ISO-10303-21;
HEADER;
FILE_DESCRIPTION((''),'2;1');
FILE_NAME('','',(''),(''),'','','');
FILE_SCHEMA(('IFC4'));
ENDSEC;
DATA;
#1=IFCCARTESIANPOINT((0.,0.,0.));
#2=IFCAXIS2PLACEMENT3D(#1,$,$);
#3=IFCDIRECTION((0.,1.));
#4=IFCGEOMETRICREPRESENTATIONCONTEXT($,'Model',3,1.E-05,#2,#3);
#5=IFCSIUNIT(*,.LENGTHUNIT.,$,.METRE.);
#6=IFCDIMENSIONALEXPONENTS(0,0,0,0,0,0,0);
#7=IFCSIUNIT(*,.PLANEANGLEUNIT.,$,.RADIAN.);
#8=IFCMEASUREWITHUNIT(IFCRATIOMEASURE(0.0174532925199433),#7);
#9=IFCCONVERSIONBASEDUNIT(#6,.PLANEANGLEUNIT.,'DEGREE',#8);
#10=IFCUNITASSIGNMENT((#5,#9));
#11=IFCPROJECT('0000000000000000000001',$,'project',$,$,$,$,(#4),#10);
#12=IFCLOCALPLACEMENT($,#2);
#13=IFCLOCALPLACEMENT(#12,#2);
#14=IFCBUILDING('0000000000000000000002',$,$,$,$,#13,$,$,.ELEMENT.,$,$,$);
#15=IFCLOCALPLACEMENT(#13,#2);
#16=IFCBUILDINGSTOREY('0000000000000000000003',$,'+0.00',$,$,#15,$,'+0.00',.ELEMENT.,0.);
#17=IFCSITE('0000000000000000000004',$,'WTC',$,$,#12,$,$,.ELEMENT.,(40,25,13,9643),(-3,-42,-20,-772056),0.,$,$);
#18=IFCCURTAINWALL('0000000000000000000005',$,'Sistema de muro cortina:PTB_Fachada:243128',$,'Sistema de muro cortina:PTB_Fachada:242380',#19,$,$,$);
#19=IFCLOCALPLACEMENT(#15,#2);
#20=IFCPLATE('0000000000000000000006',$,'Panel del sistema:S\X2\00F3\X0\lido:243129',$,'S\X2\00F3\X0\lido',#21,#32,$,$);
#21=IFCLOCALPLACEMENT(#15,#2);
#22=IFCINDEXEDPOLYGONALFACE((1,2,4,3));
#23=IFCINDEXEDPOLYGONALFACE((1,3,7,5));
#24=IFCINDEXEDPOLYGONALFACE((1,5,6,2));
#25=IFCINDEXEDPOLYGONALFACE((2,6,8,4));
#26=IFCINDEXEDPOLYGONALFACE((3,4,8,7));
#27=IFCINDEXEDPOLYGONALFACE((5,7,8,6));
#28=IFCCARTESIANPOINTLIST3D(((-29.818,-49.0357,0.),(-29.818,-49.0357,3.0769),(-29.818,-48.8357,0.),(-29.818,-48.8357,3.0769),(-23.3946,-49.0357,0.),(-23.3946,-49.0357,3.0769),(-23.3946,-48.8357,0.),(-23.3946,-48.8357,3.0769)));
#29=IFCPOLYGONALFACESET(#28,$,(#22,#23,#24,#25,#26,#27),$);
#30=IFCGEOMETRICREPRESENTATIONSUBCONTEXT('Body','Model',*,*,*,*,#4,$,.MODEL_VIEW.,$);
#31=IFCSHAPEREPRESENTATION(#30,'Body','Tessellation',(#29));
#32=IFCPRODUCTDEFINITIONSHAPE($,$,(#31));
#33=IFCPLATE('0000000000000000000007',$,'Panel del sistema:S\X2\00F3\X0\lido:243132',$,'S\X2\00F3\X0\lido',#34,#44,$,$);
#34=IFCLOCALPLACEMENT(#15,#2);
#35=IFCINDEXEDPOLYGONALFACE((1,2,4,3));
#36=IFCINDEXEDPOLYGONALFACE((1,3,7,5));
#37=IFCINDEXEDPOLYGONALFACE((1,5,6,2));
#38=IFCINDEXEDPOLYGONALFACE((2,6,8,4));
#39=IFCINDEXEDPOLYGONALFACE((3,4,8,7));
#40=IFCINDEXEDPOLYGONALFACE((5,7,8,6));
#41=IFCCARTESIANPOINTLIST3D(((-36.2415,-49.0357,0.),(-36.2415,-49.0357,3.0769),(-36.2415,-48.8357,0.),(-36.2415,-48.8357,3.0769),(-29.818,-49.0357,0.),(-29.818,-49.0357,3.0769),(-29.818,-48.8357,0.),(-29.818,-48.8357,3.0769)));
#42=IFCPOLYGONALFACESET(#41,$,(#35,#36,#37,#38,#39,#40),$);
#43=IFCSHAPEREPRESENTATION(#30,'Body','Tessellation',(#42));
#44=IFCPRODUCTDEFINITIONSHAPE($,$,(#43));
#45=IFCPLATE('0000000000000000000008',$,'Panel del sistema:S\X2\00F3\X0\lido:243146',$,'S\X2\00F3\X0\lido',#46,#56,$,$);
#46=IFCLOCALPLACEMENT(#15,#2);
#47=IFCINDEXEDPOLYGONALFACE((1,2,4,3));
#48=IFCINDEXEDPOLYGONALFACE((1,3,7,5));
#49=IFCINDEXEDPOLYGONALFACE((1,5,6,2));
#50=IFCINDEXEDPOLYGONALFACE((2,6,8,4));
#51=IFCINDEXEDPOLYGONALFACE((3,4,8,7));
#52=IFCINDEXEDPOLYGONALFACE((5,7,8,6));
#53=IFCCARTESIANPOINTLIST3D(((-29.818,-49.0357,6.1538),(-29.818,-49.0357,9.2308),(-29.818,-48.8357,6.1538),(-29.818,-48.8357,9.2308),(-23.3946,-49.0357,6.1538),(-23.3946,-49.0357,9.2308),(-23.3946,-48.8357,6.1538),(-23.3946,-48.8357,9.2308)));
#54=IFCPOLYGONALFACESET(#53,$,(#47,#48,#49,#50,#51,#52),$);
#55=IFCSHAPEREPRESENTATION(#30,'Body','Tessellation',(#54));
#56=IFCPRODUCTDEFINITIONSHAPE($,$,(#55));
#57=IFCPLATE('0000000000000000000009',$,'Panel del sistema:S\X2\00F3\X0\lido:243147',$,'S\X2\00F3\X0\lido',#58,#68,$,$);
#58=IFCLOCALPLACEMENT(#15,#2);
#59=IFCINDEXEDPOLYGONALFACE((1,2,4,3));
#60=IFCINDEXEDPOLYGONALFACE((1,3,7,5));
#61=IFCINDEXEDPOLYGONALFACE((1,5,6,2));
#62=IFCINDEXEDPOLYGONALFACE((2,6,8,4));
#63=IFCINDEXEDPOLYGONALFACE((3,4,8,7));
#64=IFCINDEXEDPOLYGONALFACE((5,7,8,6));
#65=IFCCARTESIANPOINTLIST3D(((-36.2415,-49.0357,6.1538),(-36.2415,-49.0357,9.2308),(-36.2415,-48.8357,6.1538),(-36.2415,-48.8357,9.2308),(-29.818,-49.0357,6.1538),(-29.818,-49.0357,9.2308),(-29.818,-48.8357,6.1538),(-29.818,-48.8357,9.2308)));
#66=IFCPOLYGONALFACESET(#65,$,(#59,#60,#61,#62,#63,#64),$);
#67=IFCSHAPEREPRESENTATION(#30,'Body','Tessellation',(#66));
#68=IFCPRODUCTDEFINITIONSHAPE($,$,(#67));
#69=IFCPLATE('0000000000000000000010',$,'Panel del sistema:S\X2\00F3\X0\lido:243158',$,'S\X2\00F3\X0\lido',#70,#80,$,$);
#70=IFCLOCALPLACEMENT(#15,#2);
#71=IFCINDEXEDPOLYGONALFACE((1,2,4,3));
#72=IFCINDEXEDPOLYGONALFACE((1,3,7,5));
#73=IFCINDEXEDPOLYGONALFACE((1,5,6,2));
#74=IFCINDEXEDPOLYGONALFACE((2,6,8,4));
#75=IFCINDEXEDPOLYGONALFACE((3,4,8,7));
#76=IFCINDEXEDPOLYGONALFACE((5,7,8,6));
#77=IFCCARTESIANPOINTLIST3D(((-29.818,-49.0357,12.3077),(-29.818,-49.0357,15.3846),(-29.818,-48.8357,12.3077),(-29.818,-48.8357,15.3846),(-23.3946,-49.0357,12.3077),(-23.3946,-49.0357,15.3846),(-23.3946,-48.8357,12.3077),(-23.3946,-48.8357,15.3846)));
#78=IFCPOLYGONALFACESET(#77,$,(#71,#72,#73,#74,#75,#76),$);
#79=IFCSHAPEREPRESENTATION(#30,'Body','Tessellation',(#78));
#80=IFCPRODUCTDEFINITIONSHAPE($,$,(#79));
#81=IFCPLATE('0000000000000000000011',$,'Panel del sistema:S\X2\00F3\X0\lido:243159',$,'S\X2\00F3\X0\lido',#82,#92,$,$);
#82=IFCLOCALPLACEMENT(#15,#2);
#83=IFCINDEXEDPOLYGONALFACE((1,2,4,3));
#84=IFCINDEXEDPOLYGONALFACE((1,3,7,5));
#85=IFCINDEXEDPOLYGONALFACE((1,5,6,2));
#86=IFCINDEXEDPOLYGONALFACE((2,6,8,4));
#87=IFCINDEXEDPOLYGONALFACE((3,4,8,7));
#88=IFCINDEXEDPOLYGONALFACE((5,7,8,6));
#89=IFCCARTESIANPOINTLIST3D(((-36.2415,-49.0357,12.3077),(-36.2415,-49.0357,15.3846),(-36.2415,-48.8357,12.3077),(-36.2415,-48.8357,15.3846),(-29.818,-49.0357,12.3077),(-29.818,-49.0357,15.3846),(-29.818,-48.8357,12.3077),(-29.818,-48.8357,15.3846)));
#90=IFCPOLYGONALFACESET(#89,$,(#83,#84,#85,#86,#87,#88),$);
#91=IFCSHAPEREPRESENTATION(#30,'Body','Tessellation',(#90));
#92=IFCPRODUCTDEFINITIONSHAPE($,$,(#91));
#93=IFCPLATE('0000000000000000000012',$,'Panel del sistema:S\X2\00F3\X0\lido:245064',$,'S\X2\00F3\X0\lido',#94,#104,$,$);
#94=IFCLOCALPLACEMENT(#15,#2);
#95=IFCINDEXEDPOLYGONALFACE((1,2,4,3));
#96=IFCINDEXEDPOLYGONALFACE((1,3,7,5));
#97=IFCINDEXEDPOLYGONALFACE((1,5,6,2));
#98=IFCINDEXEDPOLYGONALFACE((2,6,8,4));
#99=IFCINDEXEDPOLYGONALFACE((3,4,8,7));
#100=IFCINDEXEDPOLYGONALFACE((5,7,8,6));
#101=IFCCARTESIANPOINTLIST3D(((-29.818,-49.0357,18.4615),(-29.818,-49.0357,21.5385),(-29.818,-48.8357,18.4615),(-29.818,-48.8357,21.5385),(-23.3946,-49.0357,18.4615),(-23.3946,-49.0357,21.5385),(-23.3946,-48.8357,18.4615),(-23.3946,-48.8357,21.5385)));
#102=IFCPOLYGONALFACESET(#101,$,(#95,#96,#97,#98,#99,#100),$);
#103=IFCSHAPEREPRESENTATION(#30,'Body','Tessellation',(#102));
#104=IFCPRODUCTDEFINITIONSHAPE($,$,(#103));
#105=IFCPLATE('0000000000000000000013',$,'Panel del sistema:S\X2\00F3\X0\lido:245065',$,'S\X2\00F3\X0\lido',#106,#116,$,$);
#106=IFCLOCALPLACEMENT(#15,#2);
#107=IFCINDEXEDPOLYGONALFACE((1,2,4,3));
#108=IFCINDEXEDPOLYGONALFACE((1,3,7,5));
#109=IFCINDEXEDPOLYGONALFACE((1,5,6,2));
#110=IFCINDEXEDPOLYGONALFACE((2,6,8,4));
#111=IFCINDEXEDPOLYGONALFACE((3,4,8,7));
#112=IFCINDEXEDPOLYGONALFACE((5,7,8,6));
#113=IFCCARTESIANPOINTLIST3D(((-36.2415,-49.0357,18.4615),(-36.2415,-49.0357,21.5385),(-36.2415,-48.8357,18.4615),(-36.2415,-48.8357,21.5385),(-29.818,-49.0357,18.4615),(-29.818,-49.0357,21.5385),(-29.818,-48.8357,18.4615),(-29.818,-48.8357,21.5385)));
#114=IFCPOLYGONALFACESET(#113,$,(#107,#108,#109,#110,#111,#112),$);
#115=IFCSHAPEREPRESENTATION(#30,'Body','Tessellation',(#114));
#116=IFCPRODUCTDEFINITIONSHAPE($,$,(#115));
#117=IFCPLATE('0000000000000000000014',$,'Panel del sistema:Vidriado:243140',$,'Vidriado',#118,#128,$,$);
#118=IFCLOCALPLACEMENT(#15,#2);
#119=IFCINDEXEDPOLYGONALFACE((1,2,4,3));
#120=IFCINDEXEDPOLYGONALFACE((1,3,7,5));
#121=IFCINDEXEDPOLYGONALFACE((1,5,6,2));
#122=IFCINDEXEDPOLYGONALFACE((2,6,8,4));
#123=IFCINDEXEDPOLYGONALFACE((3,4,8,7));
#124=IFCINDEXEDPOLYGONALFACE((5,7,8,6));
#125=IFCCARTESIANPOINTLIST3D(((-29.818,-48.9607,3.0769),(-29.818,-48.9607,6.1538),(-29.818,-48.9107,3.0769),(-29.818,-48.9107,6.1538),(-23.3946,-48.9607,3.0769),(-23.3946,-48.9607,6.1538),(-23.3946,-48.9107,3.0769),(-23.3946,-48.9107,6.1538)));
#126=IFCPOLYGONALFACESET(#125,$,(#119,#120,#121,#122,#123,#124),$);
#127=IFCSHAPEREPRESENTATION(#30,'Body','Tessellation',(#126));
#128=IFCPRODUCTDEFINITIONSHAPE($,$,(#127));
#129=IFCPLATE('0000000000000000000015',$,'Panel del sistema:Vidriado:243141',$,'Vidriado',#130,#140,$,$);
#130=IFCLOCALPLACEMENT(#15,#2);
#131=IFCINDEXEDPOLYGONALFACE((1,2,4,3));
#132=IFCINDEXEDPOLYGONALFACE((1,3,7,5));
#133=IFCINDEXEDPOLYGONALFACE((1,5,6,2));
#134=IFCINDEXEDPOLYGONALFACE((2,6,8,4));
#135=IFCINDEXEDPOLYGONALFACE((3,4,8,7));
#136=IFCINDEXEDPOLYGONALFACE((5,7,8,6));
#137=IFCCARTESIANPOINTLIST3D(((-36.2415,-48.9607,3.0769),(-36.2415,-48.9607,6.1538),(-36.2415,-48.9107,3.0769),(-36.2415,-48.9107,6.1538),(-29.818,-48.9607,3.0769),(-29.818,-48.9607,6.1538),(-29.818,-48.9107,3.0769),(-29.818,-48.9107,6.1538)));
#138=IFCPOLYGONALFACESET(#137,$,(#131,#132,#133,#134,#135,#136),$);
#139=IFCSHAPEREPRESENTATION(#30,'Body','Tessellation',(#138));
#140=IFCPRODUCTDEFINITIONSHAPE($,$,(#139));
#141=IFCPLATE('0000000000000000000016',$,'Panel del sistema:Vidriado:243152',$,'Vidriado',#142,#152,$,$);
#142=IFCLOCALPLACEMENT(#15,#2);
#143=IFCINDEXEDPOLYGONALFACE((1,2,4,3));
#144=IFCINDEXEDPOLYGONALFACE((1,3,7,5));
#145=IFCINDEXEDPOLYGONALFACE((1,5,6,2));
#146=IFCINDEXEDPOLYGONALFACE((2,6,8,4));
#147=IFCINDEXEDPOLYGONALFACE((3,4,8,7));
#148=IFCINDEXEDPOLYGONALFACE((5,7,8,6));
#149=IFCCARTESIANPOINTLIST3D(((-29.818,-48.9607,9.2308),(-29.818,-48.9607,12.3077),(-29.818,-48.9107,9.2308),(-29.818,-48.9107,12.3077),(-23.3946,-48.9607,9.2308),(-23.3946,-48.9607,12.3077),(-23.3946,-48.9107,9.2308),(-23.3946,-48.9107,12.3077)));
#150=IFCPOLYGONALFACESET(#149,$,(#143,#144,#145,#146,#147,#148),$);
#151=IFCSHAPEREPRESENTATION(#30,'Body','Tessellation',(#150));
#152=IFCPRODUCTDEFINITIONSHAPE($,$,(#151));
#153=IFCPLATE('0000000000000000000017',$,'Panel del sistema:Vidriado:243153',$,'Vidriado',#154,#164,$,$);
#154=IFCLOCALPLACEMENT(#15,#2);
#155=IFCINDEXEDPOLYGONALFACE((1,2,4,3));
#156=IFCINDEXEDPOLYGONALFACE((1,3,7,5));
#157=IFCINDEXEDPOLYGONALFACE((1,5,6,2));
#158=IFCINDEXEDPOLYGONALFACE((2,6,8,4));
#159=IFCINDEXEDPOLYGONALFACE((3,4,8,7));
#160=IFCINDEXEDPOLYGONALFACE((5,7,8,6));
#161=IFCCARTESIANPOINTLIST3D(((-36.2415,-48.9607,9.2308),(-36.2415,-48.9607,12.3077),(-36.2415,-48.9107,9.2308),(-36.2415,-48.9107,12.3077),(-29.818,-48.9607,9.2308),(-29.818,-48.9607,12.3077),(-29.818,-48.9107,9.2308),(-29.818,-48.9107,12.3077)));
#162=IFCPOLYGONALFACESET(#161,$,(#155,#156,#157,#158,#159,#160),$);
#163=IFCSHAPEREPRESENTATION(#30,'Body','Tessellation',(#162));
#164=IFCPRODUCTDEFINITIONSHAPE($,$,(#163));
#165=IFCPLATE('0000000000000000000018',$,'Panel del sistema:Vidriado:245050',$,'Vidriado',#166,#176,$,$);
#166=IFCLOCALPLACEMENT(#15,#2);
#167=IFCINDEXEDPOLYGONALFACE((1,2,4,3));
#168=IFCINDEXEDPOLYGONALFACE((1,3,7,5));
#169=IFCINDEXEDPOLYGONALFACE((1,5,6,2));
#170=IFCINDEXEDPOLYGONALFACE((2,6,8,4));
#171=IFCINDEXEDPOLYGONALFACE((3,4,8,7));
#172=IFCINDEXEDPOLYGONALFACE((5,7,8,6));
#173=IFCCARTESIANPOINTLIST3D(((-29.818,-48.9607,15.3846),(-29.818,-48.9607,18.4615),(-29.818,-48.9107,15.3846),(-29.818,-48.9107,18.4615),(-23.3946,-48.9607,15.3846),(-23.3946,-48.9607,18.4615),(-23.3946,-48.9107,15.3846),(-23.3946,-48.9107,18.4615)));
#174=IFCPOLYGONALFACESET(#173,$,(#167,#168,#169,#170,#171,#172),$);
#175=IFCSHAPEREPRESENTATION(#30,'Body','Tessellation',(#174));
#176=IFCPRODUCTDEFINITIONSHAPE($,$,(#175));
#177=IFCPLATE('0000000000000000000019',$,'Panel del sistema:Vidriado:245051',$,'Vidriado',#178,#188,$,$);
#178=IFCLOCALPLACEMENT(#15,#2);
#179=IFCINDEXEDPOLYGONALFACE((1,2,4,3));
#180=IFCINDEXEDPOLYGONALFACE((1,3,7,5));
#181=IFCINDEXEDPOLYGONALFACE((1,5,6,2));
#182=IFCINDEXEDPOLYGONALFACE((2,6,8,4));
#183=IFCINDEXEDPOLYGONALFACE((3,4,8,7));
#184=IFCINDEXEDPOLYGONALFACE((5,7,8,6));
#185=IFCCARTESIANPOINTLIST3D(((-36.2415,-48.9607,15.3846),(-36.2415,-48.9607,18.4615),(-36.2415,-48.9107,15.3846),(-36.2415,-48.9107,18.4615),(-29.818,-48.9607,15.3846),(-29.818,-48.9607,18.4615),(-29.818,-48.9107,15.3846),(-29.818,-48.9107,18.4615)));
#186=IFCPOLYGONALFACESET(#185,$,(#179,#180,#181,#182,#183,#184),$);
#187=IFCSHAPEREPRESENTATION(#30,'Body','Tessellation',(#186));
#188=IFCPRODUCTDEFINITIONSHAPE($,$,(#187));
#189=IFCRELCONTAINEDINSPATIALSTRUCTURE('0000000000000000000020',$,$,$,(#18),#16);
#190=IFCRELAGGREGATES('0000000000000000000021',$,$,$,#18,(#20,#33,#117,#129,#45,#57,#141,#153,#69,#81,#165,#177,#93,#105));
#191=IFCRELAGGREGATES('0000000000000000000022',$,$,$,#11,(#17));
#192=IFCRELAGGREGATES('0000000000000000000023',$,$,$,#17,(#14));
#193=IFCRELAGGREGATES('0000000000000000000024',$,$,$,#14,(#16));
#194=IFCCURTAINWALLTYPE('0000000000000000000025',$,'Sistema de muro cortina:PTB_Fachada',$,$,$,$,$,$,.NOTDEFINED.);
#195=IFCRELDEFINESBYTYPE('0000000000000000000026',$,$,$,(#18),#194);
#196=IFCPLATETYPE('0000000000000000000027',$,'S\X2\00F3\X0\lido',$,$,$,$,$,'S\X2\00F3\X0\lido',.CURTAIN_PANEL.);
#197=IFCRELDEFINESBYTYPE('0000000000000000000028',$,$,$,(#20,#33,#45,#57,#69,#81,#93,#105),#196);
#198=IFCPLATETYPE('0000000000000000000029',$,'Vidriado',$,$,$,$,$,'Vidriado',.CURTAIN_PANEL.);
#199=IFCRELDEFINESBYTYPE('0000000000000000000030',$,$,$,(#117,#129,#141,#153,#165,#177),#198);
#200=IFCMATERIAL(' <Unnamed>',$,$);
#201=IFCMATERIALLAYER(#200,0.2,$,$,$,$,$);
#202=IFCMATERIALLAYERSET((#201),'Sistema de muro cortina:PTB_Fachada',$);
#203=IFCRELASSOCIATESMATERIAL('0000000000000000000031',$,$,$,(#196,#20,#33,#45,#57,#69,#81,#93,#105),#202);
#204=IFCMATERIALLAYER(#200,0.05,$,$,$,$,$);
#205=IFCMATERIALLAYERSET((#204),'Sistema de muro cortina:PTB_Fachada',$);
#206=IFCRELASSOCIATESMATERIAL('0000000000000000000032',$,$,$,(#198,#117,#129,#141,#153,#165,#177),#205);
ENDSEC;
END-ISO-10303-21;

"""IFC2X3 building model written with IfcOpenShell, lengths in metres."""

from ifc_helpers import new_model, entity, si_unit, converted_unit, direction, frame, origin, origin_2d_with_axis, place, context, subcontext, project, spatial, rectangle, extrude, source, transform, mapped, material, layer, layer_set, layer_usage, type_object, type_shapes, element, aggregate, save


model = new_model("IFC2X3")

# Units and contexts
model_context = context("Model", 3, precision=1e-05, world=origin(), true_north=direction((0.0, 1.0)))
body_context = subcontext(model_context, "Body", "Model", "MODEL_VIEW")
ifc_project = project(units=[si_unit("LENGTHUNIT", "METRE"), converted_unit("PLANEANGLEUNIT", "DEGREE", entity("IfcRatioMeasure", 0.0174532925199433), si_unit("PLANEANGLEUNIT", "RADIAN"), dimensions=[0, 0, 0, 0, 0, 0, 0])], contexts=[model_context])

# Site, building, storey
site_placement = place(None, origin())
site = spatial("IfcSite", under=ifc_project, at=site_placement, Name="WTC", CompositionType="ELEMENT", RefLatitude=(40, 25, 13, 9643), RefLongitude=(-3, -42, -20, -772056), RefElevation=0.0)
building_placement = place(site_placement, origin())
building = spatial("IfcBuilding", under=site, at=building_placement, CompositionType="ELEMENT")
storey_placement = place(building_placement, origin())
storey = spatial("IfcBuildingStorey", under=building, at=storey_placement, Name="+0.00", LongName="+0.00", CompositionType="ELEMENT", Elevation=0.0)

# Curtain wall, plates
curtain_wall_type = type_object("IfcCurtainWallType", Name="Sistema de muro cortina:PTB_Fachada", PredefinedType="NOTDEFINED")
ifc_material = material(Name=" <Unnamed>")
ifc_layer_1 = layer(ifc_material, 0.2)
ifc_layer_set_1 = layer_set([ifc_layer_1], Name="Sistema de muro cortina:PTB_Fachada")
ifc_layer_2 = layer(ifc_material, 0.05)
ifc_layer_set_2 = layer_set([ifc_layer_2], Name="Sistema de muro cortina:PTB_Fachada")
curtain_wall_1_placement = place(storey_placement, origin())
curtain_wall_1 = element("IfcCurtainWall", 1, at=curtain_wall_1_placement, inside=storey, type_object=curtain_wall_type, Name="Sistema de muro cortina:PTB_Fachada:243128", ObjectType="Sistema de muro cortina:PTB_Fachada:242380")
ifc_layer_usage_1 = layer_usage(ifc_layer_set_1, "AXIS3", "POSITIVE", 0.0)
plate_type_1 = type_object("IfcPlateType", Name="Sólido", ElementType="Sólido", PredefinedType="CURTAIN_PANEL", material=ifc_layer_set_1)
shared_shape_1 = source(origin(), body_context, "Body", "SweptSolid", [
    extrude(rectangle(XDim=0.2, YDim=6.4235, at=origin_2d_with_axis()), frame((0.0, 0.0, 0.0), z_axis=(0.0, 0.0, 1.0), x_axis=(0.0, 1.0, 0.0)), (0.0, 0.0, 1.0), 3.0769),
])
type_shapes(plate_type_1, [shared_shape_1])
plate_1_placement = place(curtain_wall_1_placement, frame((-26.6063, -48.9357, 0.0), z_axis=(0.0, 0.0, 1.0), x_axis=(-1.0, 0.0, 0.0)))
plate_1 = element("IfcPlate", 2, at=plate_1_placement, type_object=plate_type_1, material=ifc_layer_usage_1, Name="Panel del sistema:Sólido:243129", ObjectType="Sólido", context=body_context, shape_type="MappedRepresentation", body=[
    mapped(shared_shape_1, transform((0.0, 0.0, 0.0), scale=1.0)),
])
ifc_layer_usage_2 = layer_usage(ifc_layer_set_1, "AXIS3", "POSITIVE", 0.0)
plate_2_placement = place(curtain_wall_1_placement, frame((-33.0298, -48.9357, 0.0), z_axis=(0.0, 0.0, 1.0), x_axis=(-1.0, 0.0, 0.0)))
plate_2 = element("IfcPlate", 3, at=plate_2_placement, type_object=plate_type_1, material=ifc_layer_usage_2, Name="Panel del sistema:Sólido:243132", ObjectType="Sólido", context=body_context, shape_type="MappedRepresentation", body=[
    mapped(shared_shape_1, transform((0.0, 0.0, 0.0), scale=1.0)),
])
ifc_layer_usage_3 = layer_usage(ifc_layer_set_1, "AXIS3", "POSITIVE", 0.0)
plate_3_placement = place(curtain_wall_1_placement, frame((-26.6063, -48.9357, 6.1538), z_axis=(0.0, 0.0, 1.0), x_axis=(-1.0, 0.0, 0.0)))
plate_3 = element("IfcPlate", 4, at=plate_3_placement, type_object=plate_type_1, material=ifc_layer_usage_3, Name="Panel del sistema:Sólido:243146", ObjectType="Sólido", context=body_context, shape_type="MappedRepresentation", body=[
    mapped(shared_shape_1, transform((0.0, 0.0, 0.0), scale=1.0)),
])
ifc_layer_usage_4 = layer_usage(ifc_layer_set_1, "AXIS3", "POSITIVE", 0.0)
plate_4_placement = place(curtain_wall_1_placement, frame((-33.0298, -48.9357, 6.1538), z_axis=(0.0, 0.0, 1.0), x_axis=(-1.0, 0.0, 0.0)))
plate_4 = element("IfcPlate", 5, at=plate_4_placement, type_object=plate_type_1, material=ifc_layer_usage_4, Name="Panel del sistema:Sólido:243147", ObjectType="Sólido", context=body_context, shape_type="MappedRepresentation", body=[
    mapped(shared_shape_1, transform((0.0, 0.0, 0.0), scale=1.0)),
])
ifc_layer_usage_5 = layer_usage(ifc_layer_set_1, "AXIS3", "POSITIVE", 0.0)
plate_5_placement = place(curtain_wall_1_placement, frame((-26.6063, -48.9357, 12.3077), z_axis=(0.0, 0.0, 1.0), x_axis=(-1.0, 0.0, 0.0)))
plate_5 = element("IfcPlate", 6, at=plate_5_placement, type_object=plate_type_1, material=ifc_layer_usage_5, Name="Panel del sistema:Sólido:243158", ObjectType="Sólido", context=body_context, shape_type="MappedRepresentation", body=[
    mapped(shared_shape_1, transform((0.0, 0.0, 0.0), scale=1.0)),
])
ifc_layer_usage_6 = layer_usage(ifc_layer_set_1, "AXIS3", "POSITIVE", 0.0)
plate_6_placement = place(curtain_wall_1_placement, frame((-33.0298, -48.9357, 12.3077), z_axis=(0.0, 0.0, 1.0), x_axis=(-1.0, 0.0, 0.0)))
plate_6 = element("IfcPlate", 7, at=plate_6_placement, type_object=plate_type_1, material=ifc_layer_usage_6, Name="Panel del sistema:Sólido:243159", ObjectType="Sólido", context=body_context, shape_type="MappedRepresentation", body=[
    mapped(shared_shape_1, transform((0.0, 0.0, 0.0), scale=1.0)),
])
ifc_layer_usage_7 = layer_usage(ifc_layer_set_1, "AXIS3", "POSITIVE", 0.0)
plate_7_placement = place(curtain_wall_1_placement, frame((-26.6063, -48.9357, 18.4615), z_axis=(0.0, 0.0, 1.0), x_axis=(-1.0, 0.0, 0.0)))
plate_7 = element("IfcPlate", 8, at=plate_7_placement, type_object=plate_type_1, material=ifc_layer_usage_7, Name="Panel del sistema:Sólido:245064", ObjectType="Sólido", context=body_context, shape_type="MappedRepresentation", body=[
    mapped(shared_shape_1, transform((0.0, 0.0, 0.0), scale=1.0)),
])
ifc_layer_usage_8 = layer_usage(ifc_layer_set_1, "AXIS3", "POSITIVE", 0.0)
plate_8_placement = place(curtain_wall_1_placement, frame((-33.0298, -48.9357, 18.4615), z_axis=(0.0, 0.0, 1.0), x_axis=(-1.0, 0.0, 0.0)))
plate_8 = element("IfcPlate", 9, at=plate_8_placement, type_object=plate_type_1, material=ifc_layer_usage_8, Name="Panel del sistema:Sólido:245065", ObjectType="Sólido", context=body_context, shape_type="MappedRepresentation", body=[
    mapped(shared_shape_1, transform((0.0, 0.0, 0.0), scale=1.0)),
])
ifc_layer_usage_9 = layer_usage(ifc_layer_set_2, "AXIS3", "POSITIVE", 0.0)
plate_type_2 = type_object("IfcPlateType", Name="Vidriado", ElementType="Vidriado", PredefinedType="CURTAIN_PANEL", material=ifc_layer_set_2)
shared_shape_2 = source(origin(), body_context, "Body", "SweptSolid", [
    extrude(rectangle(XDim=0.05, YDim=6.4235, at=origin_2d_with_axis()), frame((0.0, 0.0, 0.0), z_axis=(0.0, 0.0, 1.0), x_axis=(0.0, 1.0, 0.0)), (0.0, 0.0, 1.0), 3.0769),
])
type_shapes(plate_type_2, [shared_shape_2])
plate_9_placement = place(curtain_wall_1_placement, frame((-26.6063, -48.9357, 3.0769), z_axis=(0.0, 0.0, 1.0), x_axis=(-1.0, 0.0, 0.0)))
plate_9 = element("IfcPlate", 10, at=plate_9_placement, type_object=plate_type_2, material=ifc_layer_usage_9, Name="Panel del sistema:Vidriado:243140", ObjectType="Vidriado", context=body_context, shape_type="MappedRepresentation", body=[
    mapped(shared_shape_2, transform((0.0, 0.0, 0.0), scale=1.0)),
])
ifc_layer_usage_10 = layer_usage(ifc_layer_set_2, "AXIS3", "POSITIVE", 0.0)
plate_10_placement = place(curtain_wall_1_placement, frame((-33.0298, -48.9357, 3.0769), z_axis=(0.0, 0.0, 1.0), x_axis=(-1.0, 0.0, 0.0)))
plate_10 = element("IfcPlate", 11, at=plate_10_placement, type_object=plate_type_2, material=ifc_layer_usage_10, Name="Panel del sistema:Vidriado:243141", ObjectType="Vidriado", context=body_context, shape_type="MappedRepresentation", body=[
    mapped(shared_shape_2, transform((0.0, 0.0, 0.0), scale=1.0)),
])
ifc_layer_usage_11 = layer_usage(ifc_layer_set_2, "AXIS3", "POSITIVE", 0.0)
plate_11_placement = place(curtain_wall_1_placement, frame((-26.6063, -48.9357, 9.2308), z_axis=(0.0, 0.0, 1.0), x_axis=(-1.0, 0.0, 0.0)))
plate_11 = element("IfcPlate", 12, at=plate_11_placement, type_object=plate_type_2, material=ifc_layer_usage_11, Name="Panel del sistema:Vidriado:243152", ObjectType="Vidriado", context=body_context, shape_type="MappedRepresentation", body=[
    mapped(shared_shape_2, transform((0.0, 0.0, 0.0), scale=1.0)),
])
ifc_layer_usage_12 = layer_usage(ifc_layer_set_2, "AXIS3", "POSITIVE", 0.0)
plate_12_placement = place(curtain_wall_1_placement, frame((-33.0298, -48.9357, 9.2308), z_axis=(0.0, 0.0, 1.0), x_axis=(-1.0, 0.0, 0.0)))
plate_12 = element("IfcPlate", 13, at=plate_12_placement, type_object=plate_type_2, material=ifc_layer_usage_12, Name="Panel del sistema:Vidriado:243153", ObjectType="Vidriado", context=body_context, shape_type="MappedRepresentation", body=[
    mapped(shared_shape_2, transform((0.0, 0.0, 0.0), scale=1.0)),
])
ifc_layer_usage_13 = layer_usage(ifc_layer_set_2, "AXIS3", "POSITIVE", 0.0)
plate_13_placement = place(curtain_wall_1_placement, frame((-26.6063, -48.9357, 15.3846), z_axis=(0.0, 0.0, 1.0), x_axis=(-1.0, 0.0, 0.0)))
plate_13 = element("IfcPlate", 14, at=plate_13_placement, type_object=plate_type_2, material=ifc_layer_usage_13, Name="Panel del sistema:Vidriado:245050", ObjectType="Vidriado", context=body_context, shape_type="MappedRepresentation", body=[
    mapped(shared_shape_2, transform((0.0, 0.0, 0.0), scale=1.0)),
])
ifc_layer_usage_14 = layer_usage(ifc_layer_set_2, "AXIS3", "POSITIVE", 0.0)
plate_14_placement = place(curtain_wall_1_placement, frame((-33.0298, -48.9357, 15.3846), z_axis=(0.0, 0.0, 1.0), x_axis=(-1.0, 0.0, 0.0)))
plate_14 = element("IfcPlate", 15, at=plate_14_placement, type_object=plate_type_2, material=ifc_layer_usage_14, Name="Panel del sistema:Vidriado:245051", ObjectType="Vidriado", context=body_context, shape_type="MappedRepresentation", body=[
    mapped(shared_shape_2, transform((0.0, 0.0, 0.0), scale=1.0)),
])
aggregate(curtain_wall_1, [plate_1, plate_2, plate_9, plate_10, plate_3, plate_4, plate_11, plate_12, plate_5, plate_6, plate_13, plate_14, plate_7, plate_8])

save(model, "model.ifc")
